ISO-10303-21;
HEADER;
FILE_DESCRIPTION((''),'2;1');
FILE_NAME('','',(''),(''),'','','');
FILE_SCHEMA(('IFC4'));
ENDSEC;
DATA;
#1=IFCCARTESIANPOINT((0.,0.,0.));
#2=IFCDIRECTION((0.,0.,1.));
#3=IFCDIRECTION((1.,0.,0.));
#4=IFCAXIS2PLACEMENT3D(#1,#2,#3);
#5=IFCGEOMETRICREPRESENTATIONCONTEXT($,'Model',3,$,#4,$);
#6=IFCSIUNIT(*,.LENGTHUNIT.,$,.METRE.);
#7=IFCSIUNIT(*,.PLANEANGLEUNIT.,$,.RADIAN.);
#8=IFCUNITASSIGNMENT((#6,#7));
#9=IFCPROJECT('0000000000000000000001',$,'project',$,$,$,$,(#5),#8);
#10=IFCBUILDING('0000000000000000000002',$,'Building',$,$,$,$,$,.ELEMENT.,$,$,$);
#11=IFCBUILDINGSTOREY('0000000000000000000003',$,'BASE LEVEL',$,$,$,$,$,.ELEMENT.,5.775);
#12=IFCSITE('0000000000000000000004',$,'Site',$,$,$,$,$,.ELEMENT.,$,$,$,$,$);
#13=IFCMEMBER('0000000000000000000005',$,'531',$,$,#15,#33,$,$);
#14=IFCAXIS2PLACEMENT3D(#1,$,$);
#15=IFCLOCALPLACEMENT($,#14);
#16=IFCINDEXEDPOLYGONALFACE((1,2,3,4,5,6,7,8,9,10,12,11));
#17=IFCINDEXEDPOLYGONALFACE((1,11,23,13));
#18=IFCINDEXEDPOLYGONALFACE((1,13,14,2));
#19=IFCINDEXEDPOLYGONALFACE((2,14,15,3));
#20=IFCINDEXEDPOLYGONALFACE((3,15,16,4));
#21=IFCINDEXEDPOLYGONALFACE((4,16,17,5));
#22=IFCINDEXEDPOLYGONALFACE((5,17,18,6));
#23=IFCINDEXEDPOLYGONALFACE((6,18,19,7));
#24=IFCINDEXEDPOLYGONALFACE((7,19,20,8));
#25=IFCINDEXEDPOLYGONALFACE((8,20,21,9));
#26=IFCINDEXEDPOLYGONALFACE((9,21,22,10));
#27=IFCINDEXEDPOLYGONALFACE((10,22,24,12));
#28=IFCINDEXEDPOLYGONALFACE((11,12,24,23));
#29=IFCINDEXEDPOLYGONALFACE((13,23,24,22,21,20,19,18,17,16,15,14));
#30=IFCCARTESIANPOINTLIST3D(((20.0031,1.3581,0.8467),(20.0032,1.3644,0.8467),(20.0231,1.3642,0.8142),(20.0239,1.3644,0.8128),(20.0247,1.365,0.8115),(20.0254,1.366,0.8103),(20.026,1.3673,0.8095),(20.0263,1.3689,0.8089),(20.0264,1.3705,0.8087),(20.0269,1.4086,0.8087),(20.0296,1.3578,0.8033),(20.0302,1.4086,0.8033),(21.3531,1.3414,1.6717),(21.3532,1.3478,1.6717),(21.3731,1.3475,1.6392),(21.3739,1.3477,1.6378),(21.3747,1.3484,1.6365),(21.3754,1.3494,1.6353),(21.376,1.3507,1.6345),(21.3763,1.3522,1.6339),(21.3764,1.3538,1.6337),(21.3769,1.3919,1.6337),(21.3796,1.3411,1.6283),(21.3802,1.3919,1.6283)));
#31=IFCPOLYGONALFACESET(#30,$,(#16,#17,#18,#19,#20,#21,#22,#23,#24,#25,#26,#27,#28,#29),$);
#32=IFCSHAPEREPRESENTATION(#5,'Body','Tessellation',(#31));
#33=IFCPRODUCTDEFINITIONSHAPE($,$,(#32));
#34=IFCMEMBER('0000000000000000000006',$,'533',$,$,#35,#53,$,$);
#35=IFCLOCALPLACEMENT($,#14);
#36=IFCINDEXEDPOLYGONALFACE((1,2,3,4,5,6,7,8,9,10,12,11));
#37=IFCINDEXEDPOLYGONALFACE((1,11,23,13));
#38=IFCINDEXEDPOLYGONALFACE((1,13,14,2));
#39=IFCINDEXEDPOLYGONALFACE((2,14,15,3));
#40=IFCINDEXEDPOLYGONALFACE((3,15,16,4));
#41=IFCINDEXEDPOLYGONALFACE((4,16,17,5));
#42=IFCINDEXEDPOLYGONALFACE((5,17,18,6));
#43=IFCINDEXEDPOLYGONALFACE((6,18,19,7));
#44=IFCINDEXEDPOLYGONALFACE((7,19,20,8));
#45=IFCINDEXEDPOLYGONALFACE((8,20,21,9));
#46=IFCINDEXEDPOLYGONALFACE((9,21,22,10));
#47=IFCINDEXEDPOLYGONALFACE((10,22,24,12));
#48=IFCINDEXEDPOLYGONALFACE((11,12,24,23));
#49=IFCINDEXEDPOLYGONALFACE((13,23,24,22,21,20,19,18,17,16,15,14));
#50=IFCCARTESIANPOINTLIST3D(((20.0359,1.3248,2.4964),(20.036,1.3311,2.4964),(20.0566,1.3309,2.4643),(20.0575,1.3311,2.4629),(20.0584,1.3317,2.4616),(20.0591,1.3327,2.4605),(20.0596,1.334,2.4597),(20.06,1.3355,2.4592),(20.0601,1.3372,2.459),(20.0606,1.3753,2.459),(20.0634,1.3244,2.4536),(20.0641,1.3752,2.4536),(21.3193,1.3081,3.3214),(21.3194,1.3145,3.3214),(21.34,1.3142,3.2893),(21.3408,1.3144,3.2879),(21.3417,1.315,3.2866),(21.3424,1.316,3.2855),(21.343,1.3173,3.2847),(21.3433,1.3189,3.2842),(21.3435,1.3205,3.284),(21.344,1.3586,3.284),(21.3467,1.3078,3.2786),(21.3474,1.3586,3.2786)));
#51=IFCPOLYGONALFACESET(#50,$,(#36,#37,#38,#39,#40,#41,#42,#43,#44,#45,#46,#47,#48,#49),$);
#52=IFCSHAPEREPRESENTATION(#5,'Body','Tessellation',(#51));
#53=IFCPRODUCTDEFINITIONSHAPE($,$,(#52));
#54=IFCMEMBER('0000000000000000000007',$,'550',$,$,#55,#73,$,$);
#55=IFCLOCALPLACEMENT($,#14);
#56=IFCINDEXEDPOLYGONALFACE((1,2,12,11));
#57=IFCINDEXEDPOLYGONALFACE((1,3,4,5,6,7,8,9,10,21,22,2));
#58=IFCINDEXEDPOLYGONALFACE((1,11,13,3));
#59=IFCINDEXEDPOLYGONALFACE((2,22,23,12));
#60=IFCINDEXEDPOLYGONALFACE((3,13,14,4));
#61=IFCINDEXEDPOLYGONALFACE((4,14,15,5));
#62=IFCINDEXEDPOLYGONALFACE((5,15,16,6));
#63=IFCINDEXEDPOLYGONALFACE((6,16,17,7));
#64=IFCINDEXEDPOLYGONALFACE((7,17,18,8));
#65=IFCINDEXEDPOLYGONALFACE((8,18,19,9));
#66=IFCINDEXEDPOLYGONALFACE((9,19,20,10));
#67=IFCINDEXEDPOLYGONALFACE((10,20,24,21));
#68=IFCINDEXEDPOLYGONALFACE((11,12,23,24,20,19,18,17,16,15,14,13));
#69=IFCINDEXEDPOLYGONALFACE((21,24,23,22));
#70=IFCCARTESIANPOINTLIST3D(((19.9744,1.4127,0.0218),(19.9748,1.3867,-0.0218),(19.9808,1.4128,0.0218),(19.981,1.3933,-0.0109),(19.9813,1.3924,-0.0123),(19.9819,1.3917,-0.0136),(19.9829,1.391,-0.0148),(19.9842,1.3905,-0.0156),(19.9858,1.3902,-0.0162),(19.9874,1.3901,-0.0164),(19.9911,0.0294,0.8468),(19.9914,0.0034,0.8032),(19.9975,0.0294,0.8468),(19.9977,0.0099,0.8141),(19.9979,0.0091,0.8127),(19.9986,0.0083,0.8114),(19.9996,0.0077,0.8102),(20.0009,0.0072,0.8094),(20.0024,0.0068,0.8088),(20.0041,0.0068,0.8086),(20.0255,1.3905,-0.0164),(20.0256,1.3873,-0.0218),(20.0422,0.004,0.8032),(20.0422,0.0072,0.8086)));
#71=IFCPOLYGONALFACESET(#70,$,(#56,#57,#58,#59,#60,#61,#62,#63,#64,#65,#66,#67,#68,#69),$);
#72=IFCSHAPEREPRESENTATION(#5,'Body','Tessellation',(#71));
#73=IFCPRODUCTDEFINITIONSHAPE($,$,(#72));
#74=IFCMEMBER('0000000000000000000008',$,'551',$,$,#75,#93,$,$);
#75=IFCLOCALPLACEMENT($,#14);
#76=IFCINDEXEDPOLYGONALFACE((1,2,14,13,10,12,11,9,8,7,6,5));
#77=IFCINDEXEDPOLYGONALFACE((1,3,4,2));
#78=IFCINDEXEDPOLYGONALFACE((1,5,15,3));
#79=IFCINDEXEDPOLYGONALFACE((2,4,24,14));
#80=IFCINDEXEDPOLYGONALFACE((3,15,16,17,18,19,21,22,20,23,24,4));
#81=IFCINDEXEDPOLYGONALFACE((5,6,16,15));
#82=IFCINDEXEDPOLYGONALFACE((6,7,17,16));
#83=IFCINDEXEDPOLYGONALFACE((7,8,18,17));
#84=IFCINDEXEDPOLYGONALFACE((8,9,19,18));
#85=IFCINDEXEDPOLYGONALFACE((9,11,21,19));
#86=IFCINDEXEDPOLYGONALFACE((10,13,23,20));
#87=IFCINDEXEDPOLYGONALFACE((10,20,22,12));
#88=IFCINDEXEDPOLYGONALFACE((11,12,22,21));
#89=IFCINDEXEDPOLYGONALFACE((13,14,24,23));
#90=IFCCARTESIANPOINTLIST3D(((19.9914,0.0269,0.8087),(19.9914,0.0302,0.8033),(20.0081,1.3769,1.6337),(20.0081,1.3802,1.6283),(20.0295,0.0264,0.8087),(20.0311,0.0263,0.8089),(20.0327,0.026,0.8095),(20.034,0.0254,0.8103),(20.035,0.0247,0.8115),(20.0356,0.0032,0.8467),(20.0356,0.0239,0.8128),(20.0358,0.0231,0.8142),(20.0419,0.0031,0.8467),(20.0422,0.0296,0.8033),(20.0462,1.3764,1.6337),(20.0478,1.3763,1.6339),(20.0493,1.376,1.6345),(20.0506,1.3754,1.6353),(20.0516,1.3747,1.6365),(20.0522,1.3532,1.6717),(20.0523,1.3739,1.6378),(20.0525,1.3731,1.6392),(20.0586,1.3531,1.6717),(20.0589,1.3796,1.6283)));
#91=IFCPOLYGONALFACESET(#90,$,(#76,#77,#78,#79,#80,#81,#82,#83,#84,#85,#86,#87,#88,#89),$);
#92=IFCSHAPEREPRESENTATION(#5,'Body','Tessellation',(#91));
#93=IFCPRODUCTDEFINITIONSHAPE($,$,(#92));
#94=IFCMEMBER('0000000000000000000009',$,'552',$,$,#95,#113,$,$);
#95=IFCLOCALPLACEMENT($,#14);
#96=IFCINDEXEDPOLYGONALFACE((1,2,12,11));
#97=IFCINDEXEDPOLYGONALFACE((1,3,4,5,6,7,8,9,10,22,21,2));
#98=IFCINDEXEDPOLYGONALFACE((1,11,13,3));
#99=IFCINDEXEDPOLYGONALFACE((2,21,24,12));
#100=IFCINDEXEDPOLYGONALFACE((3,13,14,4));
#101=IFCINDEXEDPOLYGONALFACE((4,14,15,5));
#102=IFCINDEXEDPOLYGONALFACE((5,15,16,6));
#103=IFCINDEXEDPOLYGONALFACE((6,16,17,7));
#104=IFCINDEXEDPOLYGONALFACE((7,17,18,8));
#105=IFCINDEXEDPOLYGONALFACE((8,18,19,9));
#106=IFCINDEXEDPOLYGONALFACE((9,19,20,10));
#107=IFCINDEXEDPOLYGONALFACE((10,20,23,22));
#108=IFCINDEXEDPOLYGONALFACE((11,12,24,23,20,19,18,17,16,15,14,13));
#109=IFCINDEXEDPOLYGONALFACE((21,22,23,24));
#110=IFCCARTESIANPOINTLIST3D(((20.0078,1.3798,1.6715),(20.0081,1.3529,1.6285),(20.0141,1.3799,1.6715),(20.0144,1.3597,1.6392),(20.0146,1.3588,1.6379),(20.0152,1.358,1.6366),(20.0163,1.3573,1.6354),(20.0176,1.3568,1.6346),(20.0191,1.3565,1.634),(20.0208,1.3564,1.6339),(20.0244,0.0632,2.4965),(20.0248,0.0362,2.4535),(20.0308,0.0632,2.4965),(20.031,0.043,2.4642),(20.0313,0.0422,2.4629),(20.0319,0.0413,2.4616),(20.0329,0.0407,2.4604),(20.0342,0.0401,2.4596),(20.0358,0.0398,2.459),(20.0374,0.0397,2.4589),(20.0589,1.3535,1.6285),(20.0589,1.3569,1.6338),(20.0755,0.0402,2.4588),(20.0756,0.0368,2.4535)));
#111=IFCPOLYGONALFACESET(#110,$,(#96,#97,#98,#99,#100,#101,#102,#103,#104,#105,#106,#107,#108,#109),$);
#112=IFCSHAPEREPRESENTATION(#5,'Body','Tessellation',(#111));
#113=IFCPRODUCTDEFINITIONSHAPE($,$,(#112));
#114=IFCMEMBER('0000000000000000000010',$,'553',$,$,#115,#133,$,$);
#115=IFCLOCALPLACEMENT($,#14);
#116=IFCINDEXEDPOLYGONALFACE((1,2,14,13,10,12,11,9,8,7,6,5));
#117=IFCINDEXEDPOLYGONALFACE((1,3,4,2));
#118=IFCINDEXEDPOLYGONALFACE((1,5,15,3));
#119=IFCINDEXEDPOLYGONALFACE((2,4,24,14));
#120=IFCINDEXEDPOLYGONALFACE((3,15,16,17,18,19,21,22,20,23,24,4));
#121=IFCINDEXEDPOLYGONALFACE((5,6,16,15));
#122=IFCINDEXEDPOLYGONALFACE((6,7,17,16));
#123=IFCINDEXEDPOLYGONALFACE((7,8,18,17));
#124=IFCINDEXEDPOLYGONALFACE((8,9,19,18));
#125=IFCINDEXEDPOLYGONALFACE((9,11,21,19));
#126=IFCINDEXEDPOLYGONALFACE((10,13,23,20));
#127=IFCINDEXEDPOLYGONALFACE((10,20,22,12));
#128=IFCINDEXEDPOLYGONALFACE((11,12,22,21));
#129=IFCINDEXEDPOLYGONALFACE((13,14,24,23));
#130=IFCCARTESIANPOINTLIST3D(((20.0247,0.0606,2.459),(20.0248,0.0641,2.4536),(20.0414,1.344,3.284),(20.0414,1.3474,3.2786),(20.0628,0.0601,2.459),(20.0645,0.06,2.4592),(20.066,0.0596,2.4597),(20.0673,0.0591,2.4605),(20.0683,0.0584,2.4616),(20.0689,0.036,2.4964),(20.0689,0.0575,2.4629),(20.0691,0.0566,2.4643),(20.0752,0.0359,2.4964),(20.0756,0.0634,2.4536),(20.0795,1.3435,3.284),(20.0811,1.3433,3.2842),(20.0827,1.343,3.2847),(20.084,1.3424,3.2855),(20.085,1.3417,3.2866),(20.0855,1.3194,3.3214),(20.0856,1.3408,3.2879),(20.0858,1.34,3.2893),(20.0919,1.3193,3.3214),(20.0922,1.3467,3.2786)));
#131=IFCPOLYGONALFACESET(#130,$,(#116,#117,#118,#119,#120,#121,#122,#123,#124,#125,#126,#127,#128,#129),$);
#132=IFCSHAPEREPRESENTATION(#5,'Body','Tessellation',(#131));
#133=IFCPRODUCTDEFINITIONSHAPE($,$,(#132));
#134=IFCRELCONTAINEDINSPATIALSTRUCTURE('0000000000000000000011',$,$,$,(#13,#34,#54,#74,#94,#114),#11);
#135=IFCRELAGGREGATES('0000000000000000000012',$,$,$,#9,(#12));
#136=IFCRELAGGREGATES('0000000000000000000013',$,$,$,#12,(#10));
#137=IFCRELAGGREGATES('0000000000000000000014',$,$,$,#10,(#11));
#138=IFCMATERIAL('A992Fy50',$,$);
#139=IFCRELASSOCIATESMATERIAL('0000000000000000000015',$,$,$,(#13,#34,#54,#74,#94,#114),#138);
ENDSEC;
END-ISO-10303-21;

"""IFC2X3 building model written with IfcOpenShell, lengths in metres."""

from ifc_helpers import new_model, si_unit, frame, origin_with_axes, origin_2d_with_axis, place, context, project, spatial, l_section, extrude, material, element, save


model = new_model("IFC2X3")

# Units and contexts
model_context = context("Model", 3, world=origin_with_axes())
ifc_project = project(units=[si_unit("LENGTHUNIT", "METRE"), si_unit("PLANEANGLEUNIT", "RADIAN")], contexts=[model_context])

# Site, building, storey
site = spatial("IfcSite", under=ifc_project, Name="Site", CompositionType="ELEMENT")
building = spatial("IfcBuilding", under=site, Name="Building", CompositionType="ELEMENT")
storey = spatial("IfcBuildingStorey", under=building, Name="BASE LEVEL", CompositionType="ELEMENT", Elevation=5.775)

# Members
ifc_material = material(Name="A992Fy50")
member_1_placement = place(None, frame((20.0167, 1.3833, 0.825), z_axis=(0.853234, -0.010534, 0.521421), x_axis=(0.012345, 0.999924, 0.0)))
element("IfcMember", 1, at=member_1_placement, inside=storey, material=ifc_material, Name="531", context=model_context, shape_type="SweptSolid", body=[
    extrude(l_section(Depth=0.0508, Width=0.0508, Thickness=0.0063, FilletRadius=0.0063, at=origin_2d_with_axis()), origin_with_axes(), (0.0, 0.0, 1.0), 1.5822),
])
member_2_placement = place(None, frame((20.05, 1.35, 2.475), z_axis=(0.841128, -0.010924, 0.540725), x_axis=(0.012345, 0.999924, 0.0)))
element("IfcMember", 2, at=member_2_placement, inside=storey, material=ifc_material, Name="533", context=model_context, shape_type="SweptSolid", body=[
    extrude(l_section(Depth=0.0508, Width=0.0508, Thickness=0.0063, FilletRadius=0.0063, at=origin_2d_with_axis()), origin_with_axes(), (0.0, 0.0, 1.0), 1.5257),
])
member_3_placement = place(None, frame((20.0, 1.4, 0.0), z_axis=(0.010347, -0.858813, 0.512184), x_axis=(0.999927, 0.012047, 0.0)))
element("IfcMember", 3, at=member_3_placement, inside=storey, material=ifc_material, Name="550", context=model_context, shape_type="SweptSolid", body=[
    extrude(l_section(Depth=0.0508, Width=0.0508, Thickness=0.0063, FilletRadius=0.0063, at=origin_2d_with_axis()), origin_with_axes(), (0.0, 0.0, 1.0), 1.6107),
])
member_4_placement = place(None, frame((20.0167, 0.0167, 0.825), z_axis=(0.010534, 0.853234, 0.521421), x_axis=(-0.999924, 0.012345, 0.0)))
element("IfcMember", 4, at=member_4_placement, inside=storey, material=ifc_material, Name="551", context=model_context, shape_type="SweptSolid", body=[
    extrude(l_section(Depth=0.0508, Width=0.0508, Thickness=0.0063, FilletRadius=0.0063, at=origin_2d_with_axis()), origin_with_axes(), (0.0, 0.0, 1.0), 1.5822),
])
member_5_placement = place(None, frame((20.0333, 1.3667, 1.65), z_axis=(0.010726, -0.847346, 0.530932), x_axis=(0.999927, 0.012047, 0.0)))
element("IfcMember", 5, at=member_5_placement, inside=storey, material=ifc_material, Name="552", context=model_context, shape_type="SweptSolid", body=[
    extrude(l_section(Depth=0.0508, Width=0.0508, Thickness=0.0063, FilletRadius=0.0063, at=origin_2d_with_axis()), origin_with_axes(), (0.0, 0.0, 1.0), 1.5539),
])
member_6_placement = place(None, frame((20.05, 0.05, 2.475), z_axis=(0.010924, 0.841128, 0.540725), x_axis=(-0.999924, 0.012345, 0.0)))
element("IfcMember", 6, at=member_6_placement, inside=storey, material=ifc_material, Name="553", context=model_context, shape_type="SweptSolid", body=[
    extrude(l_section(Depth=0.0508, Width=0.0508, Thickness=0.0063, FilletRadius=0.0063, at=origin_2d_with_axis()), origin_with_axes(), (0.0, 0.0, 1.0), 1.5257),
])

save(model, "model.ifc")
